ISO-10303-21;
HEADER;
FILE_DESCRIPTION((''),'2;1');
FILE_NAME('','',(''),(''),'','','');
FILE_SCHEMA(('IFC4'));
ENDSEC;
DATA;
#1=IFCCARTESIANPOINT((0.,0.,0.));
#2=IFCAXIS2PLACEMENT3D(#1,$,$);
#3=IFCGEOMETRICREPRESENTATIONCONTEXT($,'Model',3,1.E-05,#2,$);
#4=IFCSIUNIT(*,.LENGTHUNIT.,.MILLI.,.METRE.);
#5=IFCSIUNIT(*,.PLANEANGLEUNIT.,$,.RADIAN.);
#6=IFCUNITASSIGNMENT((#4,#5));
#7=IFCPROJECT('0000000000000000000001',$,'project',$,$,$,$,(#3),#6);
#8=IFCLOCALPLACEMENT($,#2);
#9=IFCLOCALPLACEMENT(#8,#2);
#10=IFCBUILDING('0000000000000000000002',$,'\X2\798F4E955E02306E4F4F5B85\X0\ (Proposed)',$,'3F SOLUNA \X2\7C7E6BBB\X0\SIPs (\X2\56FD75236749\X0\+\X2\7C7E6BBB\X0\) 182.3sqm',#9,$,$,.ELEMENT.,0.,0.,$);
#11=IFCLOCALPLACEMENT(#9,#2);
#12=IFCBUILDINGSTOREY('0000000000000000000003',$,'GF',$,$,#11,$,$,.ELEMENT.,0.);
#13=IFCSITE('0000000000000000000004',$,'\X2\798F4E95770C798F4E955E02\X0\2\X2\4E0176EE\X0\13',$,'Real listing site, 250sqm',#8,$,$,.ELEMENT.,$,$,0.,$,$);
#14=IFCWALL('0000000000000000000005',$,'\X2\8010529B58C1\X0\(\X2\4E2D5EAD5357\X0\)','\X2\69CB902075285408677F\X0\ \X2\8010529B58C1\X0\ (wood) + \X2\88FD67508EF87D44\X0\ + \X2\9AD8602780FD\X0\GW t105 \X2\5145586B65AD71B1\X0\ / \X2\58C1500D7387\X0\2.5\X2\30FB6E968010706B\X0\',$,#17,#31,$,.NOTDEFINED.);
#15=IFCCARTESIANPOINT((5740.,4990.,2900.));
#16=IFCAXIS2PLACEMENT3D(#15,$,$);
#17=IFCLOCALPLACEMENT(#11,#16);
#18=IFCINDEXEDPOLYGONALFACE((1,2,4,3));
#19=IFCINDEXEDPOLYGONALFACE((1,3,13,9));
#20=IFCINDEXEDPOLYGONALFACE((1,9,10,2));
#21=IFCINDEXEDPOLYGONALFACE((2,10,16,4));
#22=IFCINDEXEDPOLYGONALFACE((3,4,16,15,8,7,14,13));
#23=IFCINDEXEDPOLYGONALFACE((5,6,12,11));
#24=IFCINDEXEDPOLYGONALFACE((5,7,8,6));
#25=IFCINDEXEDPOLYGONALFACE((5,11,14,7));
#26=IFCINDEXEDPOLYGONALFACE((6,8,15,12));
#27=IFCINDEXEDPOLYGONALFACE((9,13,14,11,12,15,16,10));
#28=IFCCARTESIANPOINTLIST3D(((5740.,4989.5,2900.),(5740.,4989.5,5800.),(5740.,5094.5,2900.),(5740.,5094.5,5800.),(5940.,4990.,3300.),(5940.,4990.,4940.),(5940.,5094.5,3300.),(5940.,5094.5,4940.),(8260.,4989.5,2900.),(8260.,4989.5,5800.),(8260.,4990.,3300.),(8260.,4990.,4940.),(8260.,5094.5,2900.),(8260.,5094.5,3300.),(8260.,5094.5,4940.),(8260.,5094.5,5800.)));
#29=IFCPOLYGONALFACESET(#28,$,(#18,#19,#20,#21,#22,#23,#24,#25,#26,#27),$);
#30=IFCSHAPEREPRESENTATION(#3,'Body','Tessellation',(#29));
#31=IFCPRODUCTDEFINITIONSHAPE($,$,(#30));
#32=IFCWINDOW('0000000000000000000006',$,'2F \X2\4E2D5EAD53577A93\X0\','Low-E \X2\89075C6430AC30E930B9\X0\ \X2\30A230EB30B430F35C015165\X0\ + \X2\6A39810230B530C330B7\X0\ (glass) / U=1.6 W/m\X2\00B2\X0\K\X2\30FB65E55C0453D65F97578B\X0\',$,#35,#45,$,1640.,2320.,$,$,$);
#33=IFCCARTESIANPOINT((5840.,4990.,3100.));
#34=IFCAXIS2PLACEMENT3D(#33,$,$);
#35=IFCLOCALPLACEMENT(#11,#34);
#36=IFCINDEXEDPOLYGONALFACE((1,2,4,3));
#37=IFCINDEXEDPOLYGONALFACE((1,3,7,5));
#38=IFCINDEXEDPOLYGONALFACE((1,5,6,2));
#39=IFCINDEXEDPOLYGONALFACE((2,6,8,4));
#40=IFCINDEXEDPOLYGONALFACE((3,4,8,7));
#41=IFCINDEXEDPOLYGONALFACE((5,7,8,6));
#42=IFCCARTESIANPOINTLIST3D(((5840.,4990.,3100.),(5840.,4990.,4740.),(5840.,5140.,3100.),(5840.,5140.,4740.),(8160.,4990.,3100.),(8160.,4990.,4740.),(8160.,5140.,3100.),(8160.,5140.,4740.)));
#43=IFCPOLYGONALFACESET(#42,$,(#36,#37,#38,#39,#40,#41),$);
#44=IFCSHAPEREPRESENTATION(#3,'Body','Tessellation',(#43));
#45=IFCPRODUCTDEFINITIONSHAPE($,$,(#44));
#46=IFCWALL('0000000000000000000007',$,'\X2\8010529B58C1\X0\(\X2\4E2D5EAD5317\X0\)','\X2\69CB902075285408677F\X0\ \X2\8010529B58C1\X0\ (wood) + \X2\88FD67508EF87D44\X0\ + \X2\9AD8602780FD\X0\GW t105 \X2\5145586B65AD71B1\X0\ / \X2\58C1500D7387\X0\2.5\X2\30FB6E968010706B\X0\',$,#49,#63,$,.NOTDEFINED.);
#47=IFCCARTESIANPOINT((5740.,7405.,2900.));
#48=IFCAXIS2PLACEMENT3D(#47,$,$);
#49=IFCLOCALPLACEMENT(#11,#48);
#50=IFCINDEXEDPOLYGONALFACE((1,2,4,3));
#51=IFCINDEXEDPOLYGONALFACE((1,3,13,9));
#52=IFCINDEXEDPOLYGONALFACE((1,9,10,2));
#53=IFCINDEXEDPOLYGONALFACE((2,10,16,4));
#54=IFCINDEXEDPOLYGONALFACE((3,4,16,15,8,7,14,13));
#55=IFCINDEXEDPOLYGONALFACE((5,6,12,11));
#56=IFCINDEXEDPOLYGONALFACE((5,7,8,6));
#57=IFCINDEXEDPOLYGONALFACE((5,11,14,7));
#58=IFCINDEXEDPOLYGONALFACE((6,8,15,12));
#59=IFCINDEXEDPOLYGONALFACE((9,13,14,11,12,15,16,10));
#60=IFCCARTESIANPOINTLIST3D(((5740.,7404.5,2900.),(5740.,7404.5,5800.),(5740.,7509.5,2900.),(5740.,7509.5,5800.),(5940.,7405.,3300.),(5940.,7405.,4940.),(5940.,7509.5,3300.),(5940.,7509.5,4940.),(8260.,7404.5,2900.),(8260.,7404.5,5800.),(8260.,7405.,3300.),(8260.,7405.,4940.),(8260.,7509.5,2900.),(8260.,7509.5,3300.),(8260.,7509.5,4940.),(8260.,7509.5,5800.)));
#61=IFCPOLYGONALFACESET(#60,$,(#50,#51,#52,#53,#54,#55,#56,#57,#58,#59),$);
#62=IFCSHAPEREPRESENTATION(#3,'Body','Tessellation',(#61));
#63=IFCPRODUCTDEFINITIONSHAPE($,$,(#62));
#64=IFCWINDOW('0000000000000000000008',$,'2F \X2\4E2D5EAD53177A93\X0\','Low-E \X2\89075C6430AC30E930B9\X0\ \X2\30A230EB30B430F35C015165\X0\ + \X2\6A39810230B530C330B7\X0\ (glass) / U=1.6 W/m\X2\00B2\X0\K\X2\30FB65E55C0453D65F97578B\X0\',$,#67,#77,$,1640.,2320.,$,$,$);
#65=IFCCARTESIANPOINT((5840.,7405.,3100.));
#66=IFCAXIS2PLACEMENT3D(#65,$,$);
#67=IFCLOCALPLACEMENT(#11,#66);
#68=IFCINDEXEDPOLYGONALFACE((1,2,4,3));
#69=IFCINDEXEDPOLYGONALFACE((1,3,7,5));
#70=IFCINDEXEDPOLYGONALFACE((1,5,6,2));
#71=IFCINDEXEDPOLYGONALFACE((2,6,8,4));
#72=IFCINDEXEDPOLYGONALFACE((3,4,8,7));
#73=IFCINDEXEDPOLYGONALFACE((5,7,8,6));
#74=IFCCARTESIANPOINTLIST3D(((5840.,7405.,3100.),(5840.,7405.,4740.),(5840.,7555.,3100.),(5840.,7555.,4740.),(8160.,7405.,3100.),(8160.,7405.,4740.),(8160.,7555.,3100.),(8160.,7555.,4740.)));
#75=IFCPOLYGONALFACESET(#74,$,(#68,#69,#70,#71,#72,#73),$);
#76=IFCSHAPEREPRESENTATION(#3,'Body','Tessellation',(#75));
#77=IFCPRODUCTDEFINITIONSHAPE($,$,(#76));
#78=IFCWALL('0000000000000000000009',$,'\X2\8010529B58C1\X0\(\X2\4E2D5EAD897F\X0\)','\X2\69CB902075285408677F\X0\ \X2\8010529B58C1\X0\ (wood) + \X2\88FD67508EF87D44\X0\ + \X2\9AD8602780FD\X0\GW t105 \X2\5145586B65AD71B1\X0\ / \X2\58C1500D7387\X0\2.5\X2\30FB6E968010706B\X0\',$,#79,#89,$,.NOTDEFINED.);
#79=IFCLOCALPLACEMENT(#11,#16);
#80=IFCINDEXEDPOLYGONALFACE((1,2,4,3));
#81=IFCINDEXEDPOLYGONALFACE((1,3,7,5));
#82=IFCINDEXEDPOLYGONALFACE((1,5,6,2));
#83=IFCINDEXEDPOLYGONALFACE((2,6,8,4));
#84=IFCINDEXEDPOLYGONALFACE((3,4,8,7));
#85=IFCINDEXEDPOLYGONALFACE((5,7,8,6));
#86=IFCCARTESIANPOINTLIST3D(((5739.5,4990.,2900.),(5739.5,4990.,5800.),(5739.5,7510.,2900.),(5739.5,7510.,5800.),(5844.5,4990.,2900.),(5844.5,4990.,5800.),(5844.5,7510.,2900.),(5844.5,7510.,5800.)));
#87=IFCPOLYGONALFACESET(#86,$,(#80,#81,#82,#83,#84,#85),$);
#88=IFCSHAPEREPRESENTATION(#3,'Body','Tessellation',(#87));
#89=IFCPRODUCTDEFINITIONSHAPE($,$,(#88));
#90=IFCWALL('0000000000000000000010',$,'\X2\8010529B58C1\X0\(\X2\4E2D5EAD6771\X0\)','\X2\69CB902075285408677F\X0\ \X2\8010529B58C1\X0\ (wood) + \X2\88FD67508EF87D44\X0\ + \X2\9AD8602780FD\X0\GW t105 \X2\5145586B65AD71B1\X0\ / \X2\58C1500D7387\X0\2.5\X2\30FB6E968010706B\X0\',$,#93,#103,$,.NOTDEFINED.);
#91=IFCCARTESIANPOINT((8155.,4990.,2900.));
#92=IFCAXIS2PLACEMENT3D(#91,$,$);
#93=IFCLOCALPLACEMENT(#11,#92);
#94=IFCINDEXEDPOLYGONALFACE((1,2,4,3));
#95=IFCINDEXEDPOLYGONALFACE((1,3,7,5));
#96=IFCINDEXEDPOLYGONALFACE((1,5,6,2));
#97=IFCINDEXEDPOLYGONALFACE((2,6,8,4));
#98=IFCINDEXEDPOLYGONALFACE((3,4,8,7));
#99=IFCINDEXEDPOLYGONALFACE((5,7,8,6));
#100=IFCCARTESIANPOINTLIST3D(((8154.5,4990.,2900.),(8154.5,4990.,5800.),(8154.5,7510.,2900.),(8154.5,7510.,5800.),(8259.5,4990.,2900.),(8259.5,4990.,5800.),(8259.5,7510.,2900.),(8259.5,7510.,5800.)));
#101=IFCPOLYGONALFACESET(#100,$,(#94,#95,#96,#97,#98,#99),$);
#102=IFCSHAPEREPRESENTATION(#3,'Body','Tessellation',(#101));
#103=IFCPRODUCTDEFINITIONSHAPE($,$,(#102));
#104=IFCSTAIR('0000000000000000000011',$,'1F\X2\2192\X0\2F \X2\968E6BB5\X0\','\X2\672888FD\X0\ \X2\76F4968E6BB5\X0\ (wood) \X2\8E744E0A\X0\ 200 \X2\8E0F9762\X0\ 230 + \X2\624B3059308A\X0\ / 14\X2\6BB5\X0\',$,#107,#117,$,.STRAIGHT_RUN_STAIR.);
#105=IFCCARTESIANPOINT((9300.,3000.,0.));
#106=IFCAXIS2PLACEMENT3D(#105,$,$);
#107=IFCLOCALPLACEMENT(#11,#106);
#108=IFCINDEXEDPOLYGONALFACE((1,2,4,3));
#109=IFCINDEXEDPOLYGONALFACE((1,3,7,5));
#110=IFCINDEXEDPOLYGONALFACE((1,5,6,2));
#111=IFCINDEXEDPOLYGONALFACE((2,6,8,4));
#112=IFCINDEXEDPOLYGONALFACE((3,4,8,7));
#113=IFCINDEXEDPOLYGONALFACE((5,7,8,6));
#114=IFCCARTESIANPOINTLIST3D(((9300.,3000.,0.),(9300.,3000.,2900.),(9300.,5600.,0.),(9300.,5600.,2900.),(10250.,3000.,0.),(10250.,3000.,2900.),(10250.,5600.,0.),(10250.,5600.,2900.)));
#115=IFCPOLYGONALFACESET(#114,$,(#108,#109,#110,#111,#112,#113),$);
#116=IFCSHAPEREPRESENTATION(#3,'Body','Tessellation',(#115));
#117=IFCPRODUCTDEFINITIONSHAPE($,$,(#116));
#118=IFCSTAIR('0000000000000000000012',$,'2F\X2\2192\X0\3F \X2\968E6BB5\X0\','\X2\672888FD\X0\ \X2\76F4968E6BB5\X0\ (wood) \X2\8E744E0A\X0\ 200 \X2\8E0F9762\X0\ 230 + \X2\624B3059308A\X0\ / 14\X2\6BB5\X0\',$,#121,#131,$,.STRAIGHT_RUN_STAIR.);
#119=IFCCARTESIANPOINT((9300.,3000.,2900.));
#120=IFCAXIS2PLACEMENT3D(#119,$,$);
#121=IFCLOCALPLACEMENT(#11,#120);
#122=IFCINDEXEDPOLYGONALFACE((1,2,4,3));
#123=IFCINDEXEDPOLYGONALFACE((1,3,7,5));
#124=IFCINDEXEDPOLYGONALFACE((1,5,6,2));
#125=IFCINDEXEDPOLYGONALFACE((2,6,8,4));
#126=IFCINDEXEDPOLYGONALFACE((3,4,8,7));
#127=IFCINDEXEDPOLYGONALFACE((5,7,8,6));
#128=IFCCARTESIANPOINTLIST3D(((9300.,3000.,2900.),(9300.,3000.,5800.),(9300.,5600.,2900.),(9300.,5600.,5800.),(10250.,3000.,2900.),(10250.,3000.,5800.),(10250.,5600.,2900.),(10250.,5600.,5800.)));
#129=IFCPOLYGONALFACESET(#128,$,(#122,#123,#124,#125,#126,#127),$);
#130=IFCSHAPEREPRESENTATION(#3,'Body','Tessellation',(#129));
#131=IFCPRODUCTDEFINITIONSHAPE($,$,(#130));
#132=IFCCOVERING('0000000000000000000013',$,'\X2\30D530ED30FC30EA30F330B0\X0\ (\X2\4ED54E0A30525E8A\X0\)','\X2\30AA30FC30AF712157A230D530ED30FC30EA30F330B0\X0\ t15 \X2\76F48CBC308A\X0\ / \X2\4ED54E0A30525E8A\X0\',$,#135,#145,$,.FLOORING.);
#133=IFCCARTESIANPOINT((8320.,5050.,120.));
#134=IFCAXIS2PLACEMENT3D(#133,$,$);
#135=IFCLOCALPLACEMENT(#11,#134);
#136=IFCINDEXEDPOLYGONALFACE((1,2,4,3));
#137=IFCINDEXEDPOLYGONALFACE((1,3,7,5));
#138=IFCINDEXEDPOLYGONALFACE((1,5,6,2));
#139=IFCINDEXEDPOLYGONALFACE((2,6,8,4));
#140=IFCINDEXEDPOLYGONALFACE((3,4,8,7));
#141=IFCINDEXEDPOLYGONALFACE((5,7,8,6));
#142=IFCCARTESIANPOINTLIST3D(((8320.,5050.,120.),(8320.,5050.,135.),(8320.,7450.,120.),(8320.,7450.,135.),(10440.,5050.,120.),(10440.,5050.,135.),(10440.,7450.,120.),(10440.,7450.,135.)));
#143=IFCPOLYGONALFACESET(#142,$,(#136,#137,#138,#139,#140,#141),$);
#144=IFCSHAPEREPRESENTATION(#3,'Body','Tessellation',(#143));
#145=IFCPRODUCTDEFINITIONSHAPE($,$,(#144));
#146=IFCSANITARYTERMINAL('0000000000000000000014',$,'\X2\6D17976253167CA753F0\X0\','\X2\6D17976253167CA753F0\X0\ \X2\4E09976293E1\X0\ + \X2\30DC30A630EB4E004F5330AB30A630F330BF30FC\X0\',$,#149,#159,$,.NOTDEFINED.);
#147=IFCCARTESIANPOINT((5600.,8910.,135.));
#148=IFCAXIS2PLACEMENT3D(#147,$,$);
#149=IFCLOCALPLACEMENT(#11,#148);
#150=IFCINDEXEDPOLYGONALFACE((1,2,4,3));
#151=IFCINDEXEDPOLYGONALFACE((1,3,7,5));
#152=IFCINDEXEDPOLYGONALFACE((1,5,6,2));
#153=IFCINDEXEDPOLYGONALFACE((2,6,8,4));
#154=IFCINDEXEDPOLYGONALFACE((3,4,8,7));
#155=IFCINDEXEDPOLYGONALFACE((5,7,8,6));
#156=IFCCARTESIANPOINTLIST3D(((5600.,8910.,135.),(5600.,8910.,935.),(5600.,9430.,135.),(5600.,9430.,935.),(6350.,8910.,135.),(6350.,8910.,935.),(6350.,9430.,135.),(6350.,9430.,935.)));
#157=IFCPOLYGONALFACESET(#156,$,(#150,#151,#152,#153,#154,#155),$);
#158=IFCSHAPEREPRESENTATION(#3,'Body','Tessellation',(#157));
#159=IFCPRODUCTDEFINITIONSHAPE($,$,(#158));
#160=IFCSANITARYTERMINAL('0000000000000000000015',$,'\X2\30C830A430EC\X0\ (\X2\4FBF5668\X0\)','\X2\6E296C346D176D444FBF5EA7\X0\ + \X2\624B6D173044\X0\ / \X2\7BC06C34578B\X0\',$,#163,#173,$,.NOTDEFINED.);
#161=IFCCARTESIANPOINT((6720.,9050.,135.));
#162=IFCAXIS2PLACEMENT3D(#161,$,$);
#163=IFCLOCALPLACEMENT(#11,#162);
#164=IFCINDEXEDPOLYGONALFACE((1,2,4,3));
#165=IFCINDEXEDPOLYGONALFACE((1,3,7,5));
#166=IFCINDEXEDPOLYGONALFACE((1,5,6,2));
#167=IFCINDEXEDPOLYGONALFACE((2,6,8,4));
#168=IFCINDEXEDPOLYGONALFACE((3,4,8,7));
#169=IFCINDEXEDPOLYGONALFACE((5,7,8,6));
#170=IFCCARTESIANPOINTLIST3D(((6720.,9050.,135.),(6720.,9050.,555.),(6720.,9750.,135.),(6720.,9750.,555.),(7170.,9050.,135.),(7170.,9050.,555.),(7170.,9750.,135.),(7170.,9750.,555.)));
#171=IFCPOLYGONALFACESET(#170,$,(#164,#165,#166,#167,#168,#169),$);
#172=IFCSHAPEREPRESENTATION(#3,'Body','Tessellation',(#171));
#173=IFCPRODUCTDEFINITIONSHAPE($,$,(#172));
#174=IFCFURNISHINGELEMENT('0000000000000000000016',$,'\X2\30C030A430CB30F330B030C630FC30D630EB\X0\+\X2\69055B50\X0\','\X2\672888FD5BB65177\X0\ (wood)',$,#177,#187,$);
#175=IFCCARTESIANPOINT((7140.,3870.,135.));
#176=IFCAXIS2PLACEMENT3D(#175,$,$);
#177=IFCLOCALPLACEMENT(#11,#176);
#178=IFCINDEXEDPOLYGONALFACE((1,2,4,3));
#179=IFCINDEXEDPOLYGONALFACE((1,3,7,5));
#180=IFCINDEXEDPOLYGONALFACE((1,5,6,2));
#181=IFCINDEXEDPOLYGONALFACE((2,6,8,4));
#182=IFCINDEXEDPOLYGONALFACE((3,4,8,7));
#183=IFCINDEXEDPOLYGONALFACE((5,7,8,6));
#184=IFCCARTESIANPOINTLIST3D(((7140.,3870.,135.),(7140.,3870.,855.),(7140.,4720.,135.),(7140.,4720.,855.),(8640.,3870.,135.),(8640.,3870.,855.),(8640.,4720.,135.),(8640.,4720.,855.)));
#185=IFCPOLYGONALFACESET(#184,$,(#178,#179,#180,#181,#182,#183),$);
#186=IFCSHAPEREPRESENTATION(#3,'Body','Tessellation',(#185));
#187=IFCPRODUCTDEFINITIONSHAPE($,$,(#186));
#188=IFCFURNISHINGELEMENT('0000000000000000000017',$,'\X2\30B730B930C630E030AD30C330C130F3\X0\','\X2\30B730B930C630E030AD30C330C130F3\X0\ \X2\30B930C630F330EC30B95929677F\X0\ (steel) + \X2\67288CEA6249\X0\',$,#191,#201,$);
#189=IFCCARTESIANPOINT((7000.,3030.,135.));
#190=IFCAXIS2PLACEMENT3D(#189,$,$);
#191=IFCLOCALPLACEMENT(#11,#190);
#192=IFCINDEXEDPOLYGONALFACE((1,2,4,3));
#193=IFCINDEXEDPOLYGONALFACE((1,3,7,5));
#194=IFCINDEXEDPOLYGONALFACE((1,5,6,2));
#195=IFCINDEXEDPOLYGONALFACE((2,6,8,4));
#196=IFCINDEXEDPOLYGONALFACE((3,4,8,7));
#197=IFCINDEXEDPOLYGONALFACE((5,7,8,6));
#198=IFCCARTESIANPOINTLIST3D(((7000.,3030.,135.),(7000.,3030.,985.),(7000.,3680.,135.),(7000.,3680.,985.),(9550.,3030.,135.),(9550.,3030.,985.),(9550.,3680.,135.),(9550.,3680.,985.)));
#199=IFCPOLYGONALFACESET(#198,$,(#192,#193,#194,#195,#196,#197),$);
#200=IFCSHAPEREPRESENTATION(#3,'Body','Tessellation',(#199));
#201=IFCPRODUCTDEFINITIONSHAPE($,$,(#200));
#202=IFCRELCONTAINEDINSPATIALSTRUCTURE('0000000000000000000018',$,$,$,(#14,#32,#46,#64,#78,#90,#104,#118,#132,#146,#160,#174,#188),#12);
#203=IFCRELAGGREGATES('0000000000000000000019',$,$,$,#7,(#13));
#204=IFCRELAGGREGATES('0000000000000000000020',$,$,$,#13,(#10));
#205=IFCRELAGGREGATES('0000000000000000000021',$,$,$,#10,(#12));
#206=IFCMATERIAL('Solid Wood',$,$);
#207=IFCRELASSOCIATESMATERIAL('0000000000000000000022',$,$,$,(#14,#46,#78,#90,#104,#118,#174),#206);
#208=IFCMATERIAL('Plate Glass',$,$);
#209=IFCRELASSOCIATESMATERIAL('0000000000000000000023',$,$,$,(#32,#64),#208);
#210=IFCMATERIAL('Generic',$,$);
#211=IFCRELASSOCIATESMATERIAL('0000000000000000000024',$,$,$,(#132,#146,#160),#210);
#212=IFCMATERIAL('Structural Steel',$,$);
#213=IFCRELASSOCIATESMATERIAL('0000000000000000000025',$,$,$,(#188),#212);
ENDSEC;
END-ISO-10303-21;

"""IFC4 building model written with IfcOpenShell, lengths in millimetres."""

from ifc_helpers import new_model, si_unit, frame, frame_2d, origin, place, context, project, spatial, rectangle, extrude, material, element, fill, save


model = new_model("IFC4")

# Units and contexts
model_context = context("Model", 3, precision=1e-05, world=origin())
ifc_project = project(units=[si_unit("LENGTHUNIT", "METRE", prefix="MILLI"), si_unit("PLANEANGLEUNIT", "RADIAN")], contexts=[model_context])

# Site, building, storey
site_placement = place(None, origin())
site = spatial("IfcSite", under=ifc_project, at=site_placement, Name="福井県福井市2丁目13", ObjectType="Real listing site, 250sqm", CompositionType="ELEMENT", RefElevation=0.0)
building_placement = place(site_placement, origin())
building = spatial("IfcBuilding", under=site, at=building_placement, Name="福井市の住宅 (Proposed)", ObjectType="3F SOLUNA 籾殻SIPs (国産杉+籾殻) 182.3sqm", CompositionType="ELEMENT", ElevationOfRefHeight=0.0, ElevationOfTerrain=0.0)
storey_placement = place(building_placement, origin())
storey = spatial("IfcBuildingStorey", under=building, at=storey_placement, Name="GF", CompositionType="ELEMENT", Elevation=0.0)

# Shared definitions
ifc_material_1 = material(Name="Solid Wood")

# Shared definitions
ifc_material_2 = material(Name="Plate Glass")

# Walls, openings, windows
wall_1_placement = place(storey_placement, frame((5740.0, 4990.0, 2900.0)))
wall_1 = element("IfcWall", 1, at=wall_1_placement, inside=storey, material=ifc_material_1, Name="耐力壁(中庭南)", Description="構造用合板 耐力壁 (wood) + 製材軸組 + 高性能GW t105 充填断熱 / 壁倍率2.5・準耐火", PredefinedType="NOTDEFINED", context=model_context, shape_type="SweptSolid", body=[
    extrude(rectangle(XDim=2520.0, YDim=105.0, at=frame_2d((1260.0, 52.0))), frame((5740.0, 4990.0, 2900.0)), (0.0, 0.0, 1.0), 2900.0),
])
opening_1_placement = place(storey_placement, frame((5840.0, 4990.0, 3100.0)))
opening_1 = element("IfcOpeningElement", 2, at=opening_1_placement, cuts=wall_1, PredefinedType="NOTDEFINED", context=model_context, shape_type="SweptSolid", body=[
    extrude(rectangle(XDim=2320.0, YDim=150.0, at=frame_2d((1160.0, 75.0))), frame((5840.0, 4990.0, 3100.0)), (0.0, 0.0, 1.0), 1640.0),
])
window_1_placement = place(storey_placement, frame((5840.0, 4990.0, 3100.0)))
window_1 = element("IfcWindow", 3, at=window_1_placement, inside=storey, material=ifc_material_2, Name="2F 中庭南窓", Description="Low-E 複層ガラス アルゴン封入 + 樹脂サッシ (glass) / U=1.6 W/m²K・日射取得型", OverallHeight=1640.0, OverallWidth=2320.0, context=model_context, shape_type="SweptSolid", body=[
    extrude(rectangle(XDim=2320.0, YDim=150.0, at=frame_2d((1160.0, 75.0))), frame((5840.0, 4990.0, 3100.0)), (0.0, 0.0, 1.0), 1640.0),
])
fill(opening_1, window_1)
wall_2_placement = place(storey_placement, frame((5740.0, 7405.0, 2900.0)))
wall_2 = element("IfcWall", 4, at=wall_2_placement, inside=storey, material=ifc_material_1, Name="耐力壁(中庭北)", Description="構造用合板 耐力壁 (wood) + 製材軸組 + 高性能GW t105 充填断熱 / 壁倍率2.5・準耐火", PredefinedType="NOTDEFINED", context=model_context, shape_type="SweptSolid", body=[
    extrude(rectangle(XDim=2520.0, YDim=105.0, at=frame_2d((1260.0, 52.0))), frame((5740.0, 7405.0, 2900.0)), (0.0, 0.0, 1.0), 2900.0),
])
opening_2_placement = place(storey_placement, frame((5840.0, 7405.0, 3100.0)))
opening_2 = element("IfcOpeningElement", 5, at=opening_2_placement, cuts=wall_2, PredefinedType="NOTDEFINED", context=model_context, shape_type="SweptSolid", body=[
    extrude(rectangle(XDim=2320.0, YDim=150.0, at=frame_2d((1160.0, 75.0))), frame((5840.0, 7405.0, 3100.0)), (0.0, 0.0, 1.0), 1640.0),
])
window_2_placement = place(storey_placement, frame((5840.0, 7405.0, 3100.0)))
window_2 = element("IfcWindow", 6, at=window_2_placement, inside=storey, material=ifc_material_2, Name="2F 中庭北窓", Description="Low-E 複層ガラス アルゴン封入 + 樹脂サッシ (glass) / U=1.6 W/m²K・日射取得型", OverallHeight=1640.0, OverallWidth=2320.0, context=model_context, shape_type="SweptSolid", body=[
    extrude(rectangle(XDim=2320.0, YDim=150.0, at=frame_2d((1160.0, 75.0))), frame((5840.0, 7405.0, 3100.0)), (0.0, 0.0, 1.0), 1640.0),
])
fill(opening_2, window_2)

# Walls
wall_3_placement = place(storey_placement, frame((5740.0, 4990.0, 2900.0)))
element("IfcWall", 7, at=wall_3_placement, inside=storey, material=ifc_material_1, Name="耐力壁(中庭西)", Description="構造用合板 耐力壁 (wood) + 製材軸組 + 高性能GW t105 充填断熱 / 壁倍率2.5・準耐火", PredefinedType="NOTDEFINED", context=model_context, shape_type="SweptSolid", body=[
    extrude(rectangle(XDim=105.0, YDim=2520.0, at=frame_2d((52.0, 1260.0))), frame((5740.0, 4990.0, 2900.0)), (0.0, 0.0, 1.0), 2900.0),
])
wall_4_placement = place(storey_placement, frame((8155.0, 4990.0, 2900.0)))
element("IfcWall", 8, at=wall_4_placement, inside=storey, material=ifc_material_1, Name="耐力壁(中庭東)", Description="構造用合板 耐力壁 (wood) + 製材軸組 + 高性能GW t105 充填断熱 / 壁倍率2.5・準耐火", PredefinedType="NOTDEFINED", context=model_context, shape_type="SweptSolid", body=[
    extrude(rectangle(XDim=105.0, YDim=2520.0, at=frame_2d((52.0, 1260.0))), frame((8155.0, 4990.0, 2900.0)), (0.0, 0.0, 1.0), 2900.0),
])

# Stairs
stair_1_placement = place(storey_placement, frame((9300.0, 3000.0, 0.0)))
element("IfcStair", 9, at=stair_1_placement, inside=storey, material=ifc_material_1, Name="1F→2F 階段", Description="木製 直階段 (wood) 蹴上 200 踏面 230 + 手すり / 14段", PredefinedType="STRAIGHT_RUN_STAIR", context=model_context, shape_type="SweptSolid", body=[
    extrude(rectangle(XDim=950.0, YDim=2600.0, at=frame_2d((475.0, 1300.0))), frame((9300.0, 3000.0, 0.0)), (0.0, 0.0, 1.0), 2900.0),
])
stair_2_placement = place(storey_placement, frame((9300.0, 3000.0, 2900.0)))
element("IfcStair", 10, at=stair_2_placement, inside=storey, material=ifc_material_1, Name="2F→3F 階段", Description="木製 直階段 (wood) 蹴上 200 踏面 230 + 手すり / 14段", PredefinedType="STRAIGHT_RUN_STAIR", context=model_context, shape_type="SweptSolid", body=[
    extrude(rectangle(XDim=950.0, YDim=2600.0, at=frame_2d((475.0, 1300.0))), frame((9300.0, 3000.0, 2900.0)), (0.0, 0.0, 1.0), 2900.0),
])

# Covering
ifc_material_3 = material(Name="Generic")
covering_placement = place(storey_placement, frame((8320.0, 5050.0, 120.0)))
element("IfcCovering", 11, at=covering_placement, inside=storey, material=ifc_material_3, Name="フローリング (仕上げ床)", Description="オーク無垢フローリング t15 直貼り / 仕上げ床", PredefinedType="FLOORING", context=model_context, shape_type="SweptSolid", body=[
    extrude(rectangle(XDim=2120.0, YDim=2400.0, at=frame_2d((1060.0, 1200.0))), frame((8320.0, 5050.0, 120.0)), (0.0, 0.0, 1.0), 15.0),
])

# Sanitary terminals
sanitary_terminal_1_placement = place(storey_placement, frame((5600.0, 8910.0, 135.0)))
element("IfcSanitaryTerminal", 12, at=sanitary_terminal_1_placement, inside=storey, material=ifc_material_3, Name="洗面化粧台", Description="洗面化粧台 三面鏡 + ボウル一体カウンター", PredefinedType="NOTDEFINED", context=model_context, shape_type="SweptSolid", body=[
    extrude(rectangle(XDim=750.0, YDim=520.0, at=frame_2d((375.0, 260.0))), frame((5600.0, 8910.0, 135.0)), (0.0, 0.0, 1.0), 800.0),
])
sanitary_terminal_2_placement = place(storey_placement, frame((6720.0, 9050.0, 135.0)))
element("IfcSanitaryTerminal", 13, at=sanitary_terminal_2_placement, inside=storey, material=ifc_material_3, Name="トイレ (便器)", Description="温水洗浄便座 + 手洗い / 節水型", PredefinedType="NOTDEFINED", context=model_context, shape_type="SweptSolid", body=[
    extrude(rectangle(XDim=450.0, YDim=700.0, at=frame_2d((225.0, 350.0))), frame((6720.0, 9050.0, 135.0)), (0.0, 0.0, 1.0), 420.0),
])

# Furnishing elements
furnishing_1_placement = place(storey_placement, frame((7140.0, 3870.0, 135.0)))
element("IfcFurnishingElement", 14, at=furnishing_1_placement, inside=storey, material=ifc_material_1, Name="ダイニングテーブル+椅子", Description="木製家具 (wood)", context=model_context, shape_type="SweptSolid", body=[
    extrude(rectangle(XDim=1500.0, YDim=850.0, at=frame_2d((750.0, 425.0))), frame((7140.0, 3870.0, 135.0)), (0.0, 0.0, 1.0), 720.0),
])
ifc_material_4 = material(Name="Structural Steel")
furnishing_2_placement = place(storey_placement, frame((7000.0, 3030.0, 135.0)))
element("IfcFurnishingElement", 15, at=furnishing_2_placement, inside=storey, material=ifc_material_4, Name="システムキッチン", Description="システムキッチン ステンレス天板 (steel) + 木質扉", context=model_context, shape_type="SweptSolid", body=[
    extrude(rectangle(XDim=2550.0, YDim=650.0, at=frame_2d((1275.0, 325.0))), frame((7000.0, 3030.0, 135.0)), (0.0, 0.0, 1.0), 850.0),
])

save(model, "model.ifc")
